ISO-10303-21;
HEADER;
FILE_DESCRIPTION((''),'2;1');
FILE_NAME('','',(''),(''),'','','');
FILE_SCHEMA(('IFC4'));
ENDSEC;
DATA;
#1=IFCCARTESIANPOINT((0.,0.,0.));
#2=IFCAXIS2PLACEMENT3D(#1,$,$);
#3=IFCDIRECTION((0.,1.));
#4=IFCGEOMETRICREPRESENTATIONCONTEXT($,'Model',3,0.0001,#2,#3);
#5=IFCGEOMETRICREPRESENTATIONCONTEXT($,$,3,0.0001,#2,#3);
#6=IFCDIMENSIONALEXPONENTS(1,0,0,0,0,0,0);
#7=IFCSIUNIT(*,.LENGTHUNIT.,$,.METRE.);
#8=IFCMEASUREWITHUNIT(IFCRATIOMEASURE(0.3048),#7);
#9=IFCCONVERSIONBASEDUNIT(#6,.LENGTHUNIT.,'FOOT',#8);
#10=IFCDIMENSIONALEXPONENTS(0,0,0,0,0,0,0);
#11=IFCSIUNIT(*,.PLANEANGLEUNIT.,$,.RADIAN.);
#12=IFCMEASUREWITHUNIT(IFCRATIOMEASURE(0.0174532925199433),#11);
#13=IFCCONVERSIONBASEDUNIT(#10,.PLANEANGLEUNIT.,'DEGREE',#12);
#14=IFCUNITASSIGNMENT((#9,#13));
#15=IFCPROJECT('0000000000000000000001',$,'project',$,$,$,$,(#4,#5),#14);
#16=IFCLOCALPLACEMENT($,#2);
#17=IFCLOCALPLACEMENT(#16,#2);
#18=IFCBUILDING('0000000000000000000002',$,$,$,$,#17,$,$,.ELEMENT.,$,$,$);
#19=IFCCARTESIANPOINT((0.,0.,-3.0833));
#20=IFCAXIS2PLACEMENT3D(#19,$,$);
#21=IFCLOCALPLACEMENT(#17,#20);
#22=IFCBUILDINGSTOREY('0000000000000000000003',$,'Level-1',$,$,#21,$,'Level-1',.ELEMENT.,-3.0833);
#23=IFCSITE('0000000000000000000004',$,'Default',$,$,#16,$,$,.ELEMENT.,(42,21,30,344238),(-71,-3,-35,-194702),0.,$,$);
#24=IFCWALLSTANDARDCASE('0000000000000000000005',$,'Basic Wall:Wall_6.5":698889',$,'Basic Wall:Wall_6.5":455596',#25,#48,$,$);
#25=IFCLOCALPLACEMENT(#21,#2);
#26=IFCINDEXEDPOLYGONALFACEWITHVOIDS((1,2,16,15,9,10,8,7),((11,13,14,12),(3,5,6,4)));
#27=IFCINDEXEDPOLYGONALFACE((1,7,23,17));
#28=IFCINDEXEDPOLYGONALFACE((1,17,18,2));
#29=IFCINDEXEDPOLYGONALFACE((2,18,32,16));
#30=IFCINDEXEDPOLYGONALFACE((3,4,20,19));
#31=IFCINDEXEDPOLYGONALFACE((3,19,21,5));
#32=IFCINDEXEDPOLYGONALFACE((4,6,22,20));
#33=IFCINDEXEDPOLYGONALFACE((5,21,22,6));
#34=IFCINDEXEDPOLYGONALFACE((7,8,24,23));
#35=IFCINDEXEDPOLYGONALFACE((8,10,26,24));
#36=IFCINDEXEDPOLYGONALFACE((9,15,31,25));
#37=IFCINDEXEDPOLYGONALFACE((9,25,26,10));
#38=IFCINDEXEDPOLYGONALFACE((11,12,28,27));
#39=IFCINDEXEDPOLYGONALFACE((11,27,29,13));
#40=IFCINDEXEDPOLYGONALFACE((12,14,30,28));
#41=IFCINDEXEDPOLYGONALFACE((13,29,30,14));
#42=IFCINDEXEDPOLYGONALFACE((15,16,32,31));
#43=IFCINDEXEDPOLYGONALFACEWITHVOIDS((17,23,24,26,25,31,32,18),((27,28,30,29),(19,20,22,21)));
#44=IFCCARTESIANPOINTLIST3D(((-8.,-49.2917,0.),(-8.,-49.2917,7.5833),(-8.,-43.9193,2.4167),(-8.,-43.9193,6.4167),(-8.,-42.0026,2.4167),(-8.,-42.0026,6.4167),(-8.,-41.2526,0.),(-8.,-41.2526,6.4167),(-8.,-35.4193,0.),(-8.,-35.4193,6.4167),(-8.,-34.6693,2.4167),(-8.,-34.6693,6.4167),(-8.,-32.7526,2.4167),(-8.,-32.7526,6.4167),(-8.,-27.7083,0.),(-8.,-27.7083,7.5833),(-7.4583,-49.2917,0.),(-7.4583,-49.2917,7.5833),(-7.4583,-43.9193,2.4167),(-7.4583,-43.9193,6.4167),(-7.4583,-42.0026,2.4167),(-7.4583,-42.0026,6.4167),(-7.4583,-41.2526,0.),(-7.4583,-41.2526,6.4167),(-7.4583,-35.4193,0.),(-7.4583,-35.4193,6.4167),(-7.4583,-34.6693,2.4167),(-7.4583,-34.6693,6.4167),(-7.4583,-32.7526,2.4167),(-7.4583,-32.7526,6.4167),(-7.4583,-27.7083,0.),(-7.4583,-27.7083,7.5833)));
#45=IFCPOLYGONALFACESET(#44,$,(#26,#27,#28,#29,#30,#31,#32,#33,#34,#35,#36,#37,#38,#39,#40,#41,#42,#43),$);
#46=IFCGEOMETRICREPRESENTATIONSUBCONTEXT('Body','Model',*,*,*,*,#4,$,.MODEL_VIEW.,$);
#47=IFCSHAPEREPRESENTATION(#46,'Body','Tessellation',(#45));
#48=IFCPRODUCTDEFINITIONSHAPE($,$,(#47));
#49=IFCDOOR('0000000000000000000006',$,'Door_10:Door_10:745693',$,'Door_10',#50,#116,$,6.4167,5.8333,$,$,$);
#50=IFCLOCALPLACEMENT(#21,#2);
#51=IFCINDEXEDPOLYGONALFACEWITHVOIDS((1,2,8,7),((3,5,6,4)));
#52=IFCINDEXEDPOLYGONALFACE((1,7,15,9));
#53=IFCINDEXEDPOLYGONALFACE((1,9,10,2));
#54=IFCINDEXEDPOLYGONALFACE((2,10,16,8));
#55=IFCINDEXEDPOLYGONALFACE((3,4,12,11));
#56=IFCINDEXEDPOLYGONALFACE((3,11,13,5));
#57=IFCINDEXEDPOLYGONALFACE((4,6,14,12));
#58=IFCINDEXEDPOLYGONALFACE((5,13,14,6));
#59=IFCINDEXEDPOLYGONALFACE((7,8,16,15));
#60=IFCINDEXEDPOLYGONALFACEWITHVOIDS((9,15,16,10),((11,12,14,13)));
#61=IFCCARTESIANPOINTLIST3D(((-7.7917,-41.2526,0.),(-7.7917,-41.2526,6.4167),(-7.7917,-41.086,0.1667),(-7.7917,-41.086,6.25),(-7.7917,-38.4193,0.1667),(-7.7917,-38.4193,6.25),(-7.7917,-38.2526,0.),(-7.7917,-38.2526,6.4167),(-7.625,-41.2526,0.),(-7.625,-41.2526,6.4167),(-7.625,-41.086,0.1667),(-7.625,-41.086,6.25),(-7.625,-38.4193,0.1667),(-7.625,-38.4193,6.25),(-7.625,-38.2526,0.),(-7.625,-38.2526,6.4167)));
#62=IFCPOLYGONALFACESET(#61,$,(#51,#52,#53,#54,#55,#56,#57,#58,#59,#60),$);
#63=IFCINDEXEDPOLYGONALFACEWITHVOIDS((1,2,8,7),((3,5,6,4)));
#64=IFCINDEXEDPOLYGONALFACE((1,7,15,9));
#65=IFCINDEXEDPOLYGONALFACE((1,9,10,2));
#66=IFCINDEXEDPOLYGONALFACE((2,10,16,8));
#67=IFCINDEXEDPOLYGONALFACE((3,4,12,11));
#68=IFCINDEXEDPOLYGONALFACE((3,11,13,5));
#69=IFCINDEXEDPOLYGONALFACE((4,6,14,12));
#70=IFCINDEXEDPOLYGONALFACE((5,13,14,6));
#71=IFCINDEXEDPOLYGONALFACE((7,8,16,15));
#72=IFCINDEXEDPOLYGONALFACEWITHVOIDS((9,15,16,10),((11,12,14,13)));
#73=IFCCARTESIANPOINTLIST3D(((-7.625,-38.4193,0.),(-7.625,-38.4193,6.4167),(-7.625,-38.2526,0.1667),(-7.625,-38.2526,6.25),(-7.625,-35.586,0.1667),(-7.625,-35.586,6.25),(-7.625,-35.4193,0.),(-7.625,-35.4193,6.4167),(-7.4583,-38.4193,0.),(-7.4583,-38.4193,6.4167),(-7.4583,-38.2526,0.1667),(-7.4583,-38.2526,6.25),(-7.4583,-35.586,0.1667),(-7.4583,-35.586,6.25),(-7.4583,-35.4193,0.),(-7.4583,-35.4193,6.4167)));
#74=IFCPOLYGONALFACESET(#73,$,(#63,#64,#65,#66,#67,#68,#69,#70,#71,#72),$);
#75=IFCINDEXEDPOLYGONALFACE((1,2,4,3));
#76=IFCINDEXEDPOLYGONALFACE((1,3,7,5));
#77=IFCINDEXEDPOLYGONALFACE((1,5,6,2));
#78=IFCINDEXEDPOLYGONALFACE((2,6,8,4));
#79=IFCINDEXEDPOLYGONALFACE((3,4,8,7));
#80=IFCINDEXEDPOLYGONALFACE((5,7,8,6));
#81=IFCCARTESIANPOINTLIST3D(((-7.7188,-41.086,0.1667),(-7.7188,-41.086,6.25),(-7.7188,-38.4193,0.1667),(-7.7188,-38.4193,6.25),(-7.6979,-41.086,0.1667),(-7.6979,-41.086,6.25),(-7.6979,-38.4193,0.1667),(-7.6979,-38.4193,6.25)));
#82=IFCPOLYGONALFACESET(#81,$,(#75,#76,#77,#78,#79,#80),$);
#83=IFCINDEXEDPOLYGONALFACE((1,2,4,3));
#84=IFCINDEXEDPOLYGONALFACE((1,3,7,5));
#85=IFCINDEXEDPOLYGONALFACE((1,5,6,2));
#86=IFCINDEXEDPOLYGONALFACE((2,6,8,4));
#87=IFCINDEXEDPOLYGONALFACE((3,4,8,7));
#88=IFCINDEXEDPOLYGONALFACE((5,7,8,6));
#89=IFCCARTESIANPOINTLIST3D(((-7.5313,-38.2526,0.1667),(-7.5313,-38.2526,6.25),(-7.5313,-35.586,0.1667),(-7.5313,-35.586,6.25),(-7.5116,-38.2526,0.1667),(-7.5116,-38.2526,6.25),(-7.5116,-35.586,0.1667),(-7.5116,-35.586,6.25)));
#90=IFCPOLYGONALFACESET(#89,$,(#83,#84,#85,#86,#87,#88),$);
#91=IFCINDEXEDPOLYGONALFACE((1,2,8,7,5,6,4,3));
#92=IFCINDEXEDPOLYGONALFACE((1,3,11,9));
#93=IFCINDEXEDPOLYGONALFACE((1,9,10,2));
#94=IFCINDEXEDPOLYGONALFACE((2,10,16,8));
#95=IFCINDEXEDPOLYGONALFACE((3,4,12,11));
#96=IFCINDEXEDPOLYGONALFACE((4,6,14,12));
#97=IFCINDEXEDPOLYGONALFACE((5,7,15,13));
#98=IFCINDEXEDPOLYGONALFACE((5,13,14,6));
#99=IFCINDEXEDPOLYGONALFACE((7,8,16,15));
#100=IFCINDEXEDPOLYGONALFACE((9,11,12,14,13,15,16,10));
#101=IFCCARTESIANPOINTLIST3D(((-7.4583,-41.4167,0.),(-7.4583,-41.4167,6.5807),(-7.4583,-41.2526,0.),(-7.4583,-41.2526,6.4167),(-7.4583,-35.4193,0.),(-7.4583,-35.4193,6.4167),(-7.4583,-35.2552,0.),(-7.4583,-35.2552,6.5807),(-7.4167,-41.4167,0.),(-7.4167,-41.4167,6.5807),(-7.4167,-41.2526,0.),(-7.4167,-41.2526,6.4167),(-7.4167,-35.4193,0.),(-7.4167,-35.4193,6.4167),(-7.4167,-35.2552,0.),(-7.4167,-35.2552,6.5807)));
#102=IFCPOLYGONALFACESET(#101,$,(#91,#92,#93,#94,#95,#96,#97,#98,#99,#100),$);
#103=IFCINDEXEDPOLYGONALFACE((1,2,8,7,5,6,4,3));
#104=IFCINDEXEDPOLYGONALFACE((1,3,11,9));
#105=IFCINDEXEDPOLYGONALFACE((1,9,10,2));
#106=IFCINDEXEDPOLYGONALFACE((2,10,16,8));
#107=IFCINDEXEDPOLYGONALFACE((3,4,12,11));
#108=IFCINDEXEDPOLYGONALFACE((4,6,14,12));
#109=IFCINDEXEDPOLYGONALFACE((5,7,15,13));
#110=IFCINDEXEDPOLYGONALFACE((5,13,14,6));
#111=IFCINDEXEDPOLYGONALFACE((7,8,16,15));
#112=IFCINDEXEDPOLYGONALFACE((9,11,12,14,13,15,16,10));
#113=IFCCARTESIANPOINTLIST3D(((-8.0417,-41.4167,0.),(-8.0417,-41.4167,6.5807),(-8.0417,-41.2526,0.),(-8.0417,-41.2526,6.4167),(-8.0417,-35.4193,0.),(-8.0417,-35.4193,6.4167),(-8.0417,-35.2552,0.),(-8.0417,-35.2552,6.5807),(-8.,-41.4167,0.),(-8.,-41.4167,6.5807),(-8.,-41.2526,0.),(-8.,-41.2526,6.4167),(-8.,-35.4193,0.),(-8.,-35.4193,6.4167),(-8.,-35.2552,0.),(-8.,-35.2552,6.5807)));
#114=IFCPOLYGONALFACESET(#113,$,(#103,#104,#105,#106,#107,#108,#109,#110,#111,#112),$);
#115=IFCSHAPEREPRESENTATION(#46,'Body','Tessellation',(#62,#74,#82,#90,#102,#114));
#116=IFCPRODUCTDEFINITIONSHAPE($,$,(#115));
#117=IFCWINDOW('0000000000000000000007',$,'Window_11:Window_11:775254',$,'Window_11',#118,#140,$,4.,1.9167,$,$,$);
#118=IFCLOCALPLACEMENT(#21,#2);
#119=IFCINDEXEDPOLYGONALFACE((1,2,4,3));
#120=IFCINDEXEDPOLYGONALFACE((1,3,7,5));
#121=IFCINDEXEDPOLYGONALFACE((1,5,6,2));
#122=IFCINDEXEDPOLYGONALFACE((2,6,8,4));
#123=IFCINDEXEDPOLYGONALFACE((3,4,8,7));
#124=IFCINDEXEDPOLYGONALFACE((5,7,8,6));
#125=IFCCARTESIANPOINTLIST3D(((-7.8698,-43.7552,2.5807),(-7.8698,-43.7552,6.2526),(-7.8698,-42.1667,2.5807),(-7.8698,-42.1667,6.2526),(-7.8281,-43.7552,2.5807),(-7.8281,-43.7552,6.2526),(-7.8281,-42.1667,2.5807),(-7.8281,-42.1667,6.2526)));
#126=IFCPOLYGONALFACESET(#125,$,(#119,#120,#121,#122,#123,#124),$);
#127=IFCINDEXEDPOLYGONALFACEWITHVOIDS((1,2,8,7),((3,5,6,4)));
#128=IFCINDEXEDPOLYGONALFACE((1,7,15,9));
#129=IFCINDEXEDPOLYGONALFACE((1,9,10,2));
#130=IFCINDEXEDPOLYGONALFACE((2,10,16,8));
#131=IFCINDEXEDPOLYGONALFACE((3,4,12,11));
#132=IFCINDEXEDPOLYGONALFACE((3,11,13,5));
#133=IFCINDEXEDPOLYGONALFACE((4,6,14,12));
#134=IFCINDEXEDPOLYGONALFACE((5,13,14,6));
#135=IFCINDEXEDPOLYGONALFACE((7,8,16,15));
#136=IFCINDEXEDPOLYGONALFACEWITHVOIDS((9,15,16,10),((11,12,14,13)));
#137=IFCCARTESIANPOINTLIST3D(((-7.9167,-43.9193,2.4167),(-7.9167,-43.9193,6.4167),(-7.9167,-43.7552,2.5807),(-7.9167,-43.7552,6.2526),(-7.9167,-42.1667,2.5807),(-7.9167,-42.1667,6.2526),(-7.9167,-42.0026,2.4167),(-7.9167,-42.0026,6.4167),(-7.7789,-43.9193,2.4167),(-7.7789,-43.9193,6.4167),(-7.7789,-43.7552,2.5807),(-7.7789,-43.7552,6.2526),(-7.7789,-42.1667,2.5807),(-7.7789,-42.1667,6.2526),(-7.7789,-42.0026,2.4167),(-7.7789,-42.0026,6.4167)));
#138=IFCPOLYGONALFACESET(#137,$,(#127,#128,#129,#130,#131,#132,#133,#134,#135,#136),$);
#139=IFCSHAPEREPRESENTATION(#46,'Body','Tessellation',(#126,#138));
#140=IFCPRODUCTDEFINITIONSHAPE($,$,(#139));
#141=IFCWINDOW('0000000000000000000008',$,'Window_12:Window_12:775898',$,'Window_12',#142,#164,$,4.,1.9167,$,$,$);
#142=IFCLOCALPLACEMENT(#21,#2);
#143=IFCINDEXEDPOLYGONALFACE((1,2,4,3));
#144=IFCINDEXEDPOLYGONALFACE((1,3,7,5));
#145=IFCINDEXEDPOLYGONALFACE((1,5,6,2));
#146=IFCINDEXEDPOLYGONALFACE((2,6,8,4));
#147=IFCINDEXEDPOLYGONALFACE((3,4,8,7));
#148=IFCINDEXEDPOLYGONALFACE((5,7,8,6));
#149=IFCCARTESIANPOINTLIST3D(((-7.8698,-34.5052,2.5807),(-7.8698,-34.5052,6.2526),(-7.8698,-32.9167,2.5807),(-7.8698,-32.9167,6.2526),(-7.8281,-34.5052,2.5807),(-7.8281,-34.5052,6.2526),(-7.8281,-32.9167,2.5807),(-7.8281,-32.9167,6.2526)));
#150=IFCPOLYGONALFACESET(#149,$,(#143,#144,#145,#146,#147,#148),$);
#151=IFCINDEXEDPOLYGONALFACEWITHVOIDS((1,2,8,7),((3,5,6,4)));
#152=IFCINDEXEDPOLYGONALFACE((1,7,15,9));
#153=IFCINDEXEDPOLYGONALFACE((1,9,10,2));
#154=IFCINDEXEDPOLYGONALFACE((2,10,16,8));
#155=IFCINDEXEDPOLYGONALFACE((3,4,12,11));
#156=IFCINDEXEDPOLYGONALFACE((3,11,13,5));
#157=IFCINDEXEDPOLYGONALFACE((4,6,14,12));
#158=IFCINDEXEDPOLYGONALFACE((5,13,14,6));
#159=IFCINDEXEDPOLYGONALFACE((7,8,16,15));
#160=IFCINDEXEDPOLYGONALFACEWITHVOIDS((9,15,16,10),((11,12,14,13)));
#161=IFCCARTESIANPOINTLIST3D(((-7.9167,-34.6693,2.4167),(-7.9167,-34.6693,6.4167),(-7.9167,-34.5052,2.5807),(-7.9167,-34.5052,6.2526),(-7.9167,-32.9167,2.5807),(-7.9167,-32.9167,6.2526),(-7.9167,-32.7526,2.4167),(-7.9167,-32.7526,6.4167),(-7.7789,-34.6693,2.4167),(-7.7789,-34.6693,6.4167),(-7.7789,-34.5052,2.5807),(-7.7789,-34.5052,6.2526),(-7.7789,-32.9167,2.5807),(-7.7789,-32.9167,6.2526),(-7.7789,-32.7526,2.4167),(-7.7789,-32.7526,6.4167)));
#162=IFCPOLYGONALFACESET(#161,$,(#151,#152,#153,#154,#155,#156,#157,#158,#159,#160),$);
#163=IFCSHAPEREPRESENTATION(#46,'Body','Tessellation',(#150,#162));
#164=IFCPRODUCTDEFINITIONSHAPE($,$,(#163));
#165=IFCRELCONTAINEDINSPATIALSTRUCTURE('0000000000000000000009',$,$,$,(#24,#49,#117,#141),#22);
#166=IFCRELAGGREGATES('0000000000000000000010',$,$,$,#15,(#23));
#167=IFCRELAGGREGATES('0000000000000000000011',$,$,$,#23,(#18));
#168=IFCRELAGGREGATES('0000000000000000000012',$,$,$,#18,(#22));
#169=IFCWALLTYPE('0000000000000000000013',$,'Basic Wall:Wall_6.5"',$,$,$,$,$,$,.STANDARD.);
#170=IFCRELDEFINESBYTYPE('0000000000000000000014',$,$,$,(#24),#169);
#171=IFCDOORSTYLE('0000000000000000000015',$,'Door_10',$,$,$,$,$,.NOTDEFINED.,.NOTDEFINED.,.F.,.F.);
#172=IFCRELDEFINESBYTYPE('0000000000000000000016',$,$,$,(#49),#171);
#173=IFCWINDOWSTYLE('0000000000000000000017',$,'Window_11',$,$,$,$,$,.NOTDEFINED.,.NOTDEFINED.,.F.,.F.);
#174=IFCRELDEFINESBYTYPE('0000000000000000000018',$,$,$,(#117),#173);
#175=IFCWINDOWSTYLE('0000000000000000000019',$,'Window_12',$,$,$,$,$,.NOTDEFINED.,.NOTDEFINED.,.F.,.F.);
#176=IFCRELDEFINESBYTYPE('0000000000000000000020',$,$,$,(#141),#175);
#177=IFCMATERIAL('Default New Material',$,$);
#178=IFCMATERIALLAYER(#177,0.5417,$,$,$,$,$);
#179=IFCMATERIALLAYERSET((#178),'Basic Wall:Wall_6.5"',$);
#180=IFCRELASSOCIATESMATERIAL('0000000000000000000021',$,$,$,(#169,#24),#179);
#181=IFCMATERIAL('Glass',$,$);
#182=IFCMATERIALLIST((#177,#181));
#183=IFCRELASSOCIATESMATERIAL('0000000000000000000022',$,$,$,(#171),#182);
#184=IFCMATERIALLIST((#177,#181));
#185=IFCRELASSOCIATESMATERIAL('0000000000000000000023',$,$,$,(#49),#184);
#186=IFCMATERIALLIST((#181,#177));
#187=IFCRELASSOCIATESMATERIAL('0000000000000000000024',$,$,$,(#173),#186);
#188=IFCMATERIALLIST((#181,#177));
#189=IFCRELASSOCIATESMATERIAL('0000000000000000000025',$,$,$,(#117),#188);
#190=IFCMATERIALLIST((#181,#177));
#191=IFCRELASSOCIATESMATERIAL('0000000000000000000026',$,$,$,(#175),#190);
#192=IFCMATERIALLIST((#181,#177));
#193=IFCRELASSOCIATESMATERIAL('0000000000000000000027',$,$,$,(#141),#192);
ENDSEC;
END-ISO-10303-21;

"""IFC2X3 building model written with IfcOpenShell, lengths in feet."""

from ifc_helpers import new_model, entity, si_unit, converted_unit, direction, frame, frame_2d, origin, origin_2d_with_axis, place, context, subcontext, project, spatial, polyline, rectangle, outline, extrude, source, transform, mapped, material, material_list, layer, layer_set, layer_usage, type_object, type_shapes, element, fill, save


model = new_model("IFC2X3")

# Units and contexts
model_context = context("Model", 3, precision=0.0001, world=origin(), true_north=direction((0.0, 1.0)))
context_of_model = context(None, 3, precision=0.0001, world=origin(), true_north=direction((0.0, 1.0)))
body_context = subcontext(model_context, "Body", "Model", "MODEL_VIEW")
ifc_project = project(units=[converted_unit("LENGTHUNIT", "FOOT", entity("IfcRatioMeasure", 0.3048), si_unit("LENGTHUNIT", "METRE"), dimensions=[1, 0, 0, 0, 0, 0, 0]), converted_unit("PLANEANGLEUNIT", "DEGREE", entity("IfcRatioMeasure", 0.0174532925199433), si_unit("PLANEANGLEUNIT", "RADIAN"), dimensions=[0, 0, 0, 0, 0, 0, 0])], contexts=[model_context, context_of_model])

# Site, building, storey
site_placement = place(None, origin())
site = spatial("IfcSite", under=ifc_project, at=site_placement, Name="Default", CompositionType="ELEMENT", RefLatitude=(42, 21, 30, 344238), RefLongitude=(-71, -3, -35, -194702), RefElevation=0.0)
building_placement = place(site_placement, origin())
building = spatial("IfcBuilding", under=site, at=building_placement, CompositionType="ELEMENT")
storey_placement = place(building_placement, frame((0.0, 0.0, -3.0833)))
storey = spatial("IfcBuildingStorey", under=building, at=storey_placement, Name="Level-1", LongName="Level-1", CompositionType="ELEMENT", Elevation=-3.0833)

# Wall, openings, door, windows
ifc_material_1 = material(Name="Default New Material")
ifc_layer_1 = layer(ifc_material_1, 0.5417)
ifc_layer_set_1 = layer_set([ifc_layer_1], Name="Basic Wall:Wall_6.5\"")
ifc_layer_usage_1 = layer_usage(ifc_layer_set_1, "AXIS2", "POSITIVE", -0.2708)
wall_type_1 = type_object("IfcWallType", Name="Basic Wall:Wall_6.5\"", PredefinedType="STANDARD", material=ifc_layer_set_1)
wall_1_placement = place(storey_placement, frame((-7.7292, -27.7083, 0.0), z_axis=(0.0, 0.0, 1.0), x_axis=(0.0, -1.0, 0.0)))
wall_1 = element("IfcWallStandardCase", 1, at=wall_1_placement, inside=storey, type_object=wall_type_1, material=ifc_layer_usage_1, Name="Basic Wall:Wall_6.5\":698889", ObjectType="Basic Wall:Wall_6.5\":455596", context=body_context, shape_type="SweptSolid", body=[
    extrude(rectangle(XDim=21.5833, YDim=0.5417, at=frame_2d((10.7917, 0.0), x_axis=(-1.0, 0.0))), origin(), (0.0, 0.0, 1.0), 7.5833),
])
opening_1_placement = place(wall_1_placement, frame((7.711, -0.2708, 0.0)))
opening_1 = element("IfcOpeningElement", 2, at=opening_1_placement, cuts=wall_1, ObjectType="Opening", context=body_context, shape_type="SweptSolid", body=[
    extrude(rectangle(XDim=6.4167, YDim=5.8333, at=frame_2d((3.2083, 2.9167), x_axis=(-1.0, 0.0))), frame((0.0, 0.0, 0.0), z_axis=(0.0, 1.0, 0.0), x_axis=(0.0, 0.0, 1.0)), (0.0, 0.0, 1.0), 0.5417),
])
opening_2_placement = place(wall_1_placement, frame((6.961, 0.2708, 2.4167)))
opening_2 = element("IfcOpeningElement", 3, at=opening_2_placement, cuts=wall_1, ObjectType="Opening", context=body_context, shape_type="SweptSolid", body=[
    extrude(rectangle(XDim=4.0, YDim=1.9167, at=frame_2d((2.0, 0.9583), x_axis=(-1.0, 0.0))), frame((0.0, 0.0, 0.0), z_axis=(0.0, -1.0, 0.0), x_axis=(0.0, 0.0, 1.0)), (0.0, 0.0, 1.0), 0.5417),
])
opening_3_placement = place(wall_1_placement, frame((16.211, 0.2708, 2.4167)))
opening_3 = element("IfcOpeningElement", 4, at=opening_3_placement, cuts=wall_1, ObjectType="Opening", context=body_context, shape_type="SweptSolid", body=[
    extrude(rectangle(XDim=4.0, YDim=1.9167, at=frame_2d((2.0, 0.9583), x_axis=(-1.0, 0.0))), frame((0.0, 0.0, 0.0), z_axis=(0.0, -1.0, 0.0), x_axis=(0.0, 0.0, 1.0)), (0.0, 0.0, 1.0), 0.5417),
])
ifc_material_2 = material(Name="Glass")
ifc_material_list_1 = material_list([ifc_material_1, ifc_material_2])
ifc_material_list_2 = material_list([ifc_material_1, ifc_material_2])
door_style_1 = type_object("IfcDoorStyle", Name="Door_10", ConstructionType="NOTDEFINED", OperationType="NOTDEFINED", ParameterTakesPrecedence=False, Sizeable=False, material=ifc_material_list_2)
shared_shape_1 = source(origin(), body_context, "Body", "SweptSolid", [
    extrude(outline(polyline([(-1.5, -3.2083), (1.5, -3.2083), (1.5, 3.2083), (-1.5, 3.2083), (-1.5, -3.2083)]), holes=[polyline([(-1.3333, -3.0417), (-1.3333, 3.0417), (1.3333, 3.0417), (1.3333, -3.0417), (-1.3333, -3.0417)])]), frame((4.3333, 0.2083, 3.2083), z_axis=(0.0, 1.0, 0.0), x_axis=(1.0, 0.0, 0.0)), (0.0, 0.0, 1.0), 0.1667),
    extrude(outline(polyline([(-3.2083, -1.5), (3.2083, -1.5), (3.2083, 1.5), (-3.2083, 1.5), (-3.2083, -1.5)]), holes=[polyline([(-3.0417, -1.3333), (-3.0417, 1.3333), (3.0417, 1.3333), (3.0417, -1.3333), (-3.0417, -1.3333)])]), frame((1.5, 0.375, 3.2083), z_axis=(0.0, 1.0, 0.0), x_axis=(0.0, 0.0, -1.0)), (0.0, 0.0, 1.0), 0.1667),
    extrude(rectangle(XDim=0.0208, YDim=2.6667, at=frame_2d((0.0, 0.0), x_axis=(1.0, 0.0))), frame((4.3333, 0.2917, 0.1667), z_axis=(0.0, 0.0, 1.0), x_axis=(0.0, -1.0, 0.0)), (0.0, 0.0, 1.0), 6.0833),
    extrude(rectangle(XDim=0.0197, YDim=2.6667, at=frame_2d((0.0, 0.0), x_axis=(1.0, 0.0))), frame((1.5, 0.4786, 0.1667), z_axis=(0.0, 0.0, 1.0), x_axis=(0.0, 1.0, 0.0)), (0.0, 0.0, 1.0), 6.0833),
    extrude(outline(polyline([(-2.9167, -3.1673), (-2.9167, 3.2493), (-3.0807, 3.2493), (-3.0807, -3.3314), (3.0807, -3.3314), (3.0807, 3.2493), (2.9167, 3.2493), (2.9167, -3.1673), (-2.9167, -3.1673)])), frame((2.9167, 0.5417, 3.2493), z_axis=(0.0, -1.0, 0.0), x_axis=(-1.0, 0.0, 0.0)), (0.0, 0.0, -1.0), 0.0417),
    extrude(outline(polyline([(-3.2493, -2.9167), (-3.2493, -3.0807), (3.3314, -3.0807), (3.3314, 3.0807), (-3.2493, 3.0807), (-3.2493, 2.9167), (3.1673, 2.9167), (3.1673, -2.9167), (-3.2493, -2.9167)])), frame((2.9167, -0.0417, 3.2493), z_axis=(0.0, -1.0, 0.0), x_axis=(0.0, 0.0, 1.0)), (0.0, 0.0, -1.0), 0.0417),
])
type_shapes(door_style_1, [shared_shape_1])
door_1_placement = place(opening_1_placement, origin())
door_1 = element("IfcDoor", 5, at=door_1_placement, inside=storey, type_object=door_style_1, material=ifc_material_list_1, Name="Door_10:Door_10:745693", ObjectType="Door_10", OverallHeight=6.4167, OverallWidth=5.8333, context=body_context, shape_type="MappedRepresentation", body=[
    mapped(shared_shape_1, transform((0.0, 0.0, 0.0), scale=1.0)),
])
fill(opening_1, door_1)
ifc_material_list_3 = material_list([ifc_material_2, ifc_material_1])
ifc_material_list_4 = material_list([ifc_material_2, ifc_material_1])
window_style_1 = type_object("IfcWindowStyle", Name="Window_11", ConstructionType="NOTDEFINED", OperationType="NOTDEFINED", ParameterTakesPrecedence=False, Sizeable=False, material=ifc_material_list_4)
shared_shape_2 = source(origin(), body_context, "Body", "SweptSolid", [
    extrude(rectangle(XDim=0.0417, YDim=1.5886, at=origin_2d_with_axis()), frame((0.9583, 0.3906, 0.164), z_axis=(0.0, 0.0, 1.0), x_axis=(0.0, 1.0, 0.0)), (0.0, 0.0, 1.0), 3.6719),
    extrude(outline(polyline([(-0.9583, -2.0), (0.9583, -2.0), (0.9583, 2.0), (-0.9583, 2.0), (-0.9583, -2.0)]), holes=[polyline([(-0.7943, -1.836), (-0.7943, 1.836), (0.7943, 1.836), (0.7943, -1.836), (-0.7943, -1.836)])]), frame((0.9583, 0.3205, 2.0), z_axis=(0.0, 1.0, 0.0), x_axis=(1.0, 0.0, 0.0)), (0.0, 0.0, 1.0), 0.1378),
])
type_shapes(window_style_1, [shared_shape_2])
window_1_placement = place(opening_3_placement, frame((0.0, 0.0, 0.0), z_axis=(0.0, 0.0, 1.0), x_axis=(-1.0, 0.0, 0.0)))
window_1 = element("IfcWindow", 6, at=window_1_placement, inside=storey, type_object=window_style_1, material=ifc_material_list_3, Name="Window_11:Window_11:775254", ObjectType="Window_11", OverallHeight=4.0, OverallWidth=1.9167, context=body_context, shape_type="MappedRepresentation", body=[
    mapped(shared_shape_2, transform((0.0, 0.0, 0.0), scale=1.0)),
])
fill(opening_3, window_1)
ifc_material_list_5 = material_list([ifc_material_2, ifc_material_1])
ifc_material_list_6 = material_list([ifc_material_2, ifc_material_1])
window_style_2 = type_object("IfcWindowStyle", Name="Window_12", ConstructionType="NOTDEFINED", OperationType="NOTDEFINED", ParameterTakesPrecedence=False, Sizeable=False, material=ifc_material_list_6)
shared_shape_3 = source(origin(), body_context, "Body", "SweptSolid", [
    extrude(rectangle(XDim=0.0417, YDim=1.5886, at=origin_2d_with_axis()), frame((0.9583, 0.3906, 0.164), z_axis=(0.0, 0.0, 1.0), x_axis=(0.0, 1.0, 0.0)), (0.0, 0.0, 1.0), 3.6719),
    extrude(outline(polyline([(-0.9583, -2.0), (0.9583, -2.0), (0.9583, 2.0), (-0.9583, 2.0), (-0.9583, -2.0)]), holes=[polyline([(-0.7943, -1.836), (-0.7943, 1.836), (0.7943, 1.836), (0.7943, -1.836), (-0.7943, -1.836)])]), frame((0.9583, 0.3205, 2.0), z_axis=(0.0, 1.0, 0.0), x_axis=(1.0, 0.0, 0.0)), (0.0, 0.0, 1.0), 0.1378),
])
type_shapes(window_style_2, [shared_shape_3])
window_2_placement = place(opening_2_placement, frame((0.0, 0.0, 0.0), z_axis=(0.0, 0.0, 1.0), x_axis=(-1.0, 0.0, 0.0)))
window_2 = element("IfcWindow", 7, at=window_2_placement, inside=storey, type_object=window_style_2, material=ifc_material_list_5, Name="Window_12:Window_12:775898", ObjectType="Window_12", OverallHeight=4.0, OverallWidth=1.9167, context=body_context, shape_type="MappedRepresentation", body=[
    mapped(shared_shape_3, transform((0.0, 0.0, 0.0), scale=1.0)),
])
fill(opening_2, window_2)

save(model, "model.ifc")
